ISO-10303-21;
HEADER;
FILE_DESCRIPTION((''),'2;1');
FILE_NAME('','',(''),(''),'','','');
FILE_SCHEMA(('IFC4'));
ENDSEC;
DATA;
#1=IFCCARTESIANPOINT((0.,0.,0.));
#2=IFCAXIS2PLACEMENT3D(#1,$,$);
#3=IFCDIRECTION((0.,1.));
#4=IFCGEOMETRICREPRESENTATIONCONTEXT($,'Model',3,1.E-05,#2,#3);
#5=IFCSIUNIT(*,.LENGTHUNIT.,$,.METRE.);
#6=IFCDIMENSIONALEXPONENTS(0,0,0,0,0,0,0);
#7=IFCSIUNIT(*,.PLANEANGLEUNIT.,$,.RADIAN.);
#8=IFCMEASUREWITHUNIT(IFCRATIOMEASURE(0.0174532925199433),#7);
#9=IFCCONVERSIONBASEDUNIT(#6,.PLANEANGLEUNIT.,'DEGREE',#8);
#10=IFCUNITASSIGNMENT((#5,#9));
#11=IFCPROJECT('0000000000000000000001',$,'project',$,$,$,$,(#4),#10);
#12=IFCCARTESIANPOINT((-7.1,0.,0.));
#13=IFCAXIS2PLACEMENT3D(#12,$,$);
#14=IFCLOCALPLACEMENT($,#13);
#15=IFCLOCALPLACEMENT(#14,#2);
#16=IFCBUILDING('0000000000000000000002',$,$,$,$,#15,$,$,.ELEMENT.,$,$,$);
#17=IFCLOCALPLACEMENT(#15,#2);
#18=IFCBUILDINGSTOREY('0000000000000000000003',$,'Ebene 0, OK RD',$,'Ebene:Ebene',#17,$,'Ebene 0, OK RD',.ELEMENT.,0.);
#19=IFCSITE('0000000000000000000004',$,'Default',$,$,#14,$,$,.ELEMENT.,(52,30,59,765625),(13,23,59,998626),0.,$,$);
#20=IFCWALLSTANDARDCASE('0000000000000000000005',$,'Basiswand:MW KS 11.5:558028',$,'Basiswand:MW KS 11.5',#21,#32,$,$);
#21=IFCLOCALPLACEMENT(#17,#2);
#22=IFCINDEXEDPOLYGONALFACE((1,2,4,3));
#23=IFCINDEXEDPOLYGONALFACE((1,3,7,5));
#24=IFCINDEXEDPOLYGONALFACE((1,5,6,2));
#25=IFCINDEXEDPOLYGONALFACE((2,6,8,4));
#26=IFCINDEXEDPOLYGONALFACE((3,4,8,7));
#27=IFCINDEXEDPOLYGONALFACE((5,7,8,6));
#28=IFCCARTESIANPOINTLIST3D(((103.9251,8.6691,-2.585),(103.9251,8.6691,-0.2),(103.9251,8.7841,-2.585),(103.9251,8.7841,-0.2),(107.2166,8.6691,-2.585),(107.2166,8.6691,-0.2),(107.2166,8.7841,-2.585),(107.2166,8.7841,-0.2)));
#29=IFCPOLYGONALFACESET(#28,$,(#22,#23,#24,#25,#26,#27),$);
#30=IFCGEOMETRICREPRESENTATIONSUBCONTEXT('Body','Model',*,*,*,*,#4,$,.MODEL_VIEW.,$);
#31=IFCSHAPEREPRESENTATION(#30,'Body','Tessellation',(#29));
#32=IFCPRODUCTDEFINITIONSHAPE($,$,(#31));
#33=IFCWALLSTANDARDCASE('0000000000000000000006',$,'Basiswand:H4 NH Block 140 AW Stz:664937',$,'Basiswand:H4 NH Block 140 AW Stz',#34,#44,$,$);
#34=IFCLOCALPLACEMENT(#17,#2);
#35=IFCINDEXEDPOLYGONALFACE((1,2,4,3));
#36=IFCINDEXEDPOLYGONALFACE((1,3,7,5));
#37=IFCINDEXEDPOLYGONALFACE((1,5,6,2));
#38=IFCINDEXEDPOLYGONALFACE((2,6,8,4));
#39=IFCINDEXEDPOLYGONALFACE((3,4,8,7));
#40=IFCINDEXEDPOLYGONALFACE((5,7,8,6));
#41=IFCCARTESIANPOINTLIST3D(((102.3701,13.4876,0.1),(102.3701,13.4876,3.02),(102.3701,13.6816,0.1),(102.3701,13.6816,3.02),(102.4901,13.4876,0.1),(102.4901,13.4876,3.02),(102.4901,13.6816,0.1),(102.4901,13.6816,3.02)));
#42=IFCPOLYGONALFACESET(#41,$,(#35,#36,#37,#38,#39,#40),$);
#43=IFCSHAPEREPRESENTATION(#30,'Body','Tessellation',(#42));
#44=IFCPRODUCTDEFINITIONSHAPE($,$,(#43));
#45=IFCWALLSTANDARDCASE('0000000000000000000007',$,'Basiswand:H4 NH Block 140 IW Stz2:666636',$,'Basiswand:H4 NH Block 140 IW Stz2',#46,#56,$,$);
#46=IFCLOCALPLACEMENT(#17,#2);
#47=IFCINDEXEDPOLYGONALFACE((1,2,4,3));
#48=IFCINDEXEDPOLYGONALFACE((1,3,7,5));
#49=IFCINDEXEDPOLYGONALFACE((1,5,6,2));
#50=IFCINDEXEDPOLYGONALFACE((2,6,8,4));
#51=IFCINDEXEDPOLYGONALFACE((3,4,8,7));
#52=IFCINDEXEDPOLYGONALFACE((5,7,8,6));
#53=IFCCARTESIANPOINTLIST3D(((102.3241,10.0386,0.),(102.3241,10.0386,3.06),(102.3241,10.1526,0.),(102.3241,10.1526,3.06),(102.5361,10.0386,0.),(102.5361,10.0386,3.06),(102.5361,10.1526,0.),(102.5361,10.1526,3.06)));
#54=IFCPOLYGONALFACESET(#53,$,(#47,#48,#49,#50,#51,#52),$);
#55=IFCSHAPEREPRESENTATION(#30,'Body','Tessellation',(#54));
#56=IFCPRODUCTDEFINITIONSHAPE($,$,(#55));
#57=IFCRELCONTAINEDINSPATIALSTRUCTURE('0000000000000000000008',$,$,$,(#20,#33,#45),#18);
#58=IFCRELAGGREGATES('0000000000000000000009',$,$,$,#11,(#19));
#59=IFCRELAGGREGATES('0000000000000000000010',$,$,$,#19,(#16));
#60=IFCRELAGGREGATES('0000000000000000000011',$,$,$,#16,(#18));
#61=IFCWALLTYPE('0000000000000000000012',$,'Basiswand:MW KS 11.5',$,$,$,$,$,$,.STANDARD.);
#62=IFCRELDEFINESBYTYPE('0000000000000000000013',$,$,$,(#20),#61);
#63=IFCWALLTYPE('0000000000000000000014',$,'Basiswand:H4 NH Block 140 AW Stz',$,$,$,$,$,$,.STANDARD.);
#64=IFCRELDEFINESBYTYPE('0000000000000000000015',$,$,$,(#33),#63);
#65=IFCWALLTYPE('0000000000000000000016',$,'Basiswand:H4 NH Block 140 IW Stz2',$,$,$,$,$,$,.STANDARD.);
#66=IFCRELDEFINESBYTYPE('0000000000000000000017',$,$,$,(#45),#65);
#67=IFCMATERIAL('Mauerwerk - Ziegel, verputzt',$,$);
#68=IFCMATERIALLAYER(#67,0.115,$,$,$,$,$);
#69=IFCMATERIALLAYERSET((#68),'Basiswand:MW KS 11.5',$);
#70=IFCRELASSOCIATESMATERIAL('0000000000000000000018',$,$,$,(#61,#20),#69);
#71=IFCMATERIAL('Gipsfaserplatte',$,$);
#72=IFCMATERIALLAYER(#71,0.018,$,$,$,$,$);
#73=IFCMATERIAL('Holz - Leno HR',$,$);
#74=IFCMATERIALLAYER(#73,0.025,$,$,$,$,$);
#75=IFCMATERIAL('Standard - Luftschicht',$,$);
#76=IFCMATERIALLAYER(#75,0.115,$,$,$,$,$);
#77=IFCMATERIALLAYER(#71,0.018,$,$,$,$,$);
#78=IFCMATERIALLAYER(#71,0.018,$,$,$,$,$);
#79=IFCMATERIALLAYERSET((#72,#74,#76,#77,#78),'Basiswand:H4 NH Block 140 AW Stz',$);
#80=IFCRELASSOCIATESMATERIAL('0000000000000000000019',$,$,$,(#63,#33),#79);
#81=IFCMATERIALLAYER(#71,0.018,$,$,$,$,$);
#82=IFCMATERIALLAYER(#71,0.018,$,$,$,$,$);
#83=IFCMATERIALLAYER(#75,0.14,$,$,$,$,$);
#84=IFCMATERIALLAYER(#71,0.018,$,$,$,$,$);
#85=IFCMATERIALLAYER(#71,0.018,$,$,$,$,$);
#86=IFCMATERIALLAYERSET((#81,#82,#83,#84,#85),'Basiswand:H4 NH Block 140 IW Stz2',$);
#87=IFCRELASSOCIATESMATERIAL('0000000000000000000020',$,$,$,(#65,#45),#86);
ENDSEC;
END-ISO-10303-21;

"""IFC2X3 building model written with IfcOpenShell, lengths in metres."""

from ifc_helpers import new_model, entity, si_unit, converted_unit, direction, frame, frame_2d, origin, place, context, subcontext, project, spatial, rectangle, extrude, material, layer, layer_set, layer_usage, type_object, element, save


model = new_model("IFC2X3")

# Units and contexts
model_context = context("Model", 3, precision=1e-05, world=origin(), true_north=direction((0.0, 1.0)))
body_context = subcontext(model_context, "Body", "Model", "MODEL_VIEW")
ifc_project = project(units=[si_unit("LENGTHUNIT", "METRE"), converted_unit("PLANEANGLEUNIT", "DEGREE", entity("IfcRatioMeasure", 0.0174532925199433), si_unit("PLANEANGLEUNIT", "RADIAN"), dimensions=[0, 0, 0, 0, 0, 0, 0])], contexts=[model_context])

# Site, building, storey
site_placement = place(None, frame((-7.1, 0.0, 0.0)))
site = spatial("IfcSite", under=ifc_project, at=site_placement, Name="Default", CompositionType="ELEMENT", RefLatitude=(52, 30, 59, 765625), RefLongitude=(13, 23, 59, 998626), RefElevation=0.0)
building_placement = place(site_placement, origin())
building = spatial("IfcBuilding", under=site, at=building_placement, CompositionType="ELEMENT")
storey_placement = place(building_placement, origin())
storey = spatial("IfcBuildingStorey", under=building, at=storey_placement, Name="Ebene 0, OK RD", ObjectType="Ebene:Ebene", LongName="Ebene 0, OK RD", CompositionType="ELEMENT", Elevation=0.0)

# Shared definitions
ifc_material_1 = material(Name="Gipsfaserplatte")
ifc_material_2 = material(Name="Holz - Leno HR")

# Walls
ifc_material_3 = material(Name="Mauerwerk - Ziegel, verputzt")
ifc_layer_1 = layer(ifc_material_3, 0.115)
ifc_layer_set_1 = layer_set([ifc_layer_1], Name="Basiswand:MW KS 11.5")
ifc_layer_usage_1 = layer_usage(ifc_layer_set_1, "AXIS2", "NEGATIVE", 0.0575)
wall_type_1 = type_object("IfcWallType", Name="Basiswand:MW KS 11.5", PredefinedType="STANDARD", material=ifc_layer_set_1)
wall_1_placement = place(storey_placement, frame((103.9251, 8.7266, -2.585)))
element("IfcWallStandardCase", 1, at=wall_1_placement, inside=storey, type_object=wall_type_1, material=ifc_layer_usage_1, Name="Basiswand:MW KS 11.5:558028", ObjectType="Basiswand:MW KS 11.5", context=body_context, shape_type="SweptSolid", body=[
    extrude(rectangle(XDim=3.2915, YDim=0.115, at=frame_2d((1.6457, 0.0), x_axis=(-1.0, 0.0))), origin(), (0.0, 0.0, 1.0), 2.385),
])
ifc_layer_2 = layer(ifc_material_1, 0.018)
ifc_layer_3 = layer(ifc_material_2, 0.025)
ifc_material_4 = material(Name="Standard - Luftschicht")
ifc_layer_4 = layer(ifc_material_4, 0.115)
ifc_layer_5 = layer(ifc_material_1, 0.018)
ifc_layer_6 = layer(ifc_material_1, 0.018)
ifc_layer_set_2 = layer_set([ifc_layer_2, ifc_layer_3, ifc_layer_4, ifc_layer_5, ifc_layer_6], Name="Basiswand:H4 NH Block 140 AW Stz")
ifc_layer_usage_2 = layer_usage(ifc_layer_set_2, "AXIS2", "NEGATIVE", 0.097)
wall_type_2 = type_object("IfcWallType", Name="Basiswand:H4 NH Block 140 AW Stz", PredefinedType="STANDARD", material=ifc_layer_set_2)
wall_2_placement = place(storey_placement, frame((102.3701, 13.5846, 0.1)))
element("IfcWallStandardCase", 2, at=wall_2_placement, inside=storey, type_object=wall_type_2, material=ifc_layer_usage_2, Name="Basiswand:H4 NH Block 140 AW Stz:664937", ObjectType="Basiswand:H4 NH Block 140 AW Stz", context=body_context, shape_type="SweptSolid", body=[
    extrude(rectangle(XDim=0.12, YDim=0.194, at=frame_2d((0.06, 0.0), x_axis=(-1.0, 0.0))), origin(), (0.0, 0.0, 1.0), 2.92),
])
ifc_layer_7 = layer(ifc_material_1, 0.018)
ifc_layer_8 = layer(ifc_material_1, 0.018)
ifc_layer_9 = layer(ifc_material_4, 0.14)
ifc_layer_10 = layer(ifc_material_1, 0.018)
ifc_layer_11 = layer(ifc_material_1, 0.018)
ifc_layer_set_3 = layer_set([ifc_layer_7, ifc_layer_8, ifc_layer_9, ifc_layer_10, ifc_layer_11], Name="Basiswand:H4 NH Block 140 IW Stz2")
ifc_layer_usage_3 = layer_usage(ifc_layer_set_3, "AXIS2", "NEGATIVE", 0.106)
wall_type_3 = type_object("IfcWallType", Name="Basiswand:H4 NH Block 140 IW Stz2", PredefinedType="STANDARD", material=ifc_layer_set_3)
wall_3_placement = place(storey_placement, frame((102.4301, 10.0386, 0.0), z_axis=(0.0, 0.0, 1.0), x_axis=(0.0, 1.0, 0.0)))
element("IfcWallStandardCase", 3, at=wall_3_placement, inside=storey, type_object=wall_type_3, material=ifc_layer_usage_3, Name="Basiswand:H4 NH Block 140 IW Stz2:666636", ObjectType="Basiswand:H4 NH Block 140 IW Stz2", context=body_context, shape_type="SweptSolid", body=[
    extrude(rectangle(XDim=0.114, YDim=0.212, at=frame_2d((0.057, 0.0), x_axis=(-1.0, 0.0))), origin(), (0.0, 0.0, 1.0), 3.06),
])

save(model, "model.ifc")
